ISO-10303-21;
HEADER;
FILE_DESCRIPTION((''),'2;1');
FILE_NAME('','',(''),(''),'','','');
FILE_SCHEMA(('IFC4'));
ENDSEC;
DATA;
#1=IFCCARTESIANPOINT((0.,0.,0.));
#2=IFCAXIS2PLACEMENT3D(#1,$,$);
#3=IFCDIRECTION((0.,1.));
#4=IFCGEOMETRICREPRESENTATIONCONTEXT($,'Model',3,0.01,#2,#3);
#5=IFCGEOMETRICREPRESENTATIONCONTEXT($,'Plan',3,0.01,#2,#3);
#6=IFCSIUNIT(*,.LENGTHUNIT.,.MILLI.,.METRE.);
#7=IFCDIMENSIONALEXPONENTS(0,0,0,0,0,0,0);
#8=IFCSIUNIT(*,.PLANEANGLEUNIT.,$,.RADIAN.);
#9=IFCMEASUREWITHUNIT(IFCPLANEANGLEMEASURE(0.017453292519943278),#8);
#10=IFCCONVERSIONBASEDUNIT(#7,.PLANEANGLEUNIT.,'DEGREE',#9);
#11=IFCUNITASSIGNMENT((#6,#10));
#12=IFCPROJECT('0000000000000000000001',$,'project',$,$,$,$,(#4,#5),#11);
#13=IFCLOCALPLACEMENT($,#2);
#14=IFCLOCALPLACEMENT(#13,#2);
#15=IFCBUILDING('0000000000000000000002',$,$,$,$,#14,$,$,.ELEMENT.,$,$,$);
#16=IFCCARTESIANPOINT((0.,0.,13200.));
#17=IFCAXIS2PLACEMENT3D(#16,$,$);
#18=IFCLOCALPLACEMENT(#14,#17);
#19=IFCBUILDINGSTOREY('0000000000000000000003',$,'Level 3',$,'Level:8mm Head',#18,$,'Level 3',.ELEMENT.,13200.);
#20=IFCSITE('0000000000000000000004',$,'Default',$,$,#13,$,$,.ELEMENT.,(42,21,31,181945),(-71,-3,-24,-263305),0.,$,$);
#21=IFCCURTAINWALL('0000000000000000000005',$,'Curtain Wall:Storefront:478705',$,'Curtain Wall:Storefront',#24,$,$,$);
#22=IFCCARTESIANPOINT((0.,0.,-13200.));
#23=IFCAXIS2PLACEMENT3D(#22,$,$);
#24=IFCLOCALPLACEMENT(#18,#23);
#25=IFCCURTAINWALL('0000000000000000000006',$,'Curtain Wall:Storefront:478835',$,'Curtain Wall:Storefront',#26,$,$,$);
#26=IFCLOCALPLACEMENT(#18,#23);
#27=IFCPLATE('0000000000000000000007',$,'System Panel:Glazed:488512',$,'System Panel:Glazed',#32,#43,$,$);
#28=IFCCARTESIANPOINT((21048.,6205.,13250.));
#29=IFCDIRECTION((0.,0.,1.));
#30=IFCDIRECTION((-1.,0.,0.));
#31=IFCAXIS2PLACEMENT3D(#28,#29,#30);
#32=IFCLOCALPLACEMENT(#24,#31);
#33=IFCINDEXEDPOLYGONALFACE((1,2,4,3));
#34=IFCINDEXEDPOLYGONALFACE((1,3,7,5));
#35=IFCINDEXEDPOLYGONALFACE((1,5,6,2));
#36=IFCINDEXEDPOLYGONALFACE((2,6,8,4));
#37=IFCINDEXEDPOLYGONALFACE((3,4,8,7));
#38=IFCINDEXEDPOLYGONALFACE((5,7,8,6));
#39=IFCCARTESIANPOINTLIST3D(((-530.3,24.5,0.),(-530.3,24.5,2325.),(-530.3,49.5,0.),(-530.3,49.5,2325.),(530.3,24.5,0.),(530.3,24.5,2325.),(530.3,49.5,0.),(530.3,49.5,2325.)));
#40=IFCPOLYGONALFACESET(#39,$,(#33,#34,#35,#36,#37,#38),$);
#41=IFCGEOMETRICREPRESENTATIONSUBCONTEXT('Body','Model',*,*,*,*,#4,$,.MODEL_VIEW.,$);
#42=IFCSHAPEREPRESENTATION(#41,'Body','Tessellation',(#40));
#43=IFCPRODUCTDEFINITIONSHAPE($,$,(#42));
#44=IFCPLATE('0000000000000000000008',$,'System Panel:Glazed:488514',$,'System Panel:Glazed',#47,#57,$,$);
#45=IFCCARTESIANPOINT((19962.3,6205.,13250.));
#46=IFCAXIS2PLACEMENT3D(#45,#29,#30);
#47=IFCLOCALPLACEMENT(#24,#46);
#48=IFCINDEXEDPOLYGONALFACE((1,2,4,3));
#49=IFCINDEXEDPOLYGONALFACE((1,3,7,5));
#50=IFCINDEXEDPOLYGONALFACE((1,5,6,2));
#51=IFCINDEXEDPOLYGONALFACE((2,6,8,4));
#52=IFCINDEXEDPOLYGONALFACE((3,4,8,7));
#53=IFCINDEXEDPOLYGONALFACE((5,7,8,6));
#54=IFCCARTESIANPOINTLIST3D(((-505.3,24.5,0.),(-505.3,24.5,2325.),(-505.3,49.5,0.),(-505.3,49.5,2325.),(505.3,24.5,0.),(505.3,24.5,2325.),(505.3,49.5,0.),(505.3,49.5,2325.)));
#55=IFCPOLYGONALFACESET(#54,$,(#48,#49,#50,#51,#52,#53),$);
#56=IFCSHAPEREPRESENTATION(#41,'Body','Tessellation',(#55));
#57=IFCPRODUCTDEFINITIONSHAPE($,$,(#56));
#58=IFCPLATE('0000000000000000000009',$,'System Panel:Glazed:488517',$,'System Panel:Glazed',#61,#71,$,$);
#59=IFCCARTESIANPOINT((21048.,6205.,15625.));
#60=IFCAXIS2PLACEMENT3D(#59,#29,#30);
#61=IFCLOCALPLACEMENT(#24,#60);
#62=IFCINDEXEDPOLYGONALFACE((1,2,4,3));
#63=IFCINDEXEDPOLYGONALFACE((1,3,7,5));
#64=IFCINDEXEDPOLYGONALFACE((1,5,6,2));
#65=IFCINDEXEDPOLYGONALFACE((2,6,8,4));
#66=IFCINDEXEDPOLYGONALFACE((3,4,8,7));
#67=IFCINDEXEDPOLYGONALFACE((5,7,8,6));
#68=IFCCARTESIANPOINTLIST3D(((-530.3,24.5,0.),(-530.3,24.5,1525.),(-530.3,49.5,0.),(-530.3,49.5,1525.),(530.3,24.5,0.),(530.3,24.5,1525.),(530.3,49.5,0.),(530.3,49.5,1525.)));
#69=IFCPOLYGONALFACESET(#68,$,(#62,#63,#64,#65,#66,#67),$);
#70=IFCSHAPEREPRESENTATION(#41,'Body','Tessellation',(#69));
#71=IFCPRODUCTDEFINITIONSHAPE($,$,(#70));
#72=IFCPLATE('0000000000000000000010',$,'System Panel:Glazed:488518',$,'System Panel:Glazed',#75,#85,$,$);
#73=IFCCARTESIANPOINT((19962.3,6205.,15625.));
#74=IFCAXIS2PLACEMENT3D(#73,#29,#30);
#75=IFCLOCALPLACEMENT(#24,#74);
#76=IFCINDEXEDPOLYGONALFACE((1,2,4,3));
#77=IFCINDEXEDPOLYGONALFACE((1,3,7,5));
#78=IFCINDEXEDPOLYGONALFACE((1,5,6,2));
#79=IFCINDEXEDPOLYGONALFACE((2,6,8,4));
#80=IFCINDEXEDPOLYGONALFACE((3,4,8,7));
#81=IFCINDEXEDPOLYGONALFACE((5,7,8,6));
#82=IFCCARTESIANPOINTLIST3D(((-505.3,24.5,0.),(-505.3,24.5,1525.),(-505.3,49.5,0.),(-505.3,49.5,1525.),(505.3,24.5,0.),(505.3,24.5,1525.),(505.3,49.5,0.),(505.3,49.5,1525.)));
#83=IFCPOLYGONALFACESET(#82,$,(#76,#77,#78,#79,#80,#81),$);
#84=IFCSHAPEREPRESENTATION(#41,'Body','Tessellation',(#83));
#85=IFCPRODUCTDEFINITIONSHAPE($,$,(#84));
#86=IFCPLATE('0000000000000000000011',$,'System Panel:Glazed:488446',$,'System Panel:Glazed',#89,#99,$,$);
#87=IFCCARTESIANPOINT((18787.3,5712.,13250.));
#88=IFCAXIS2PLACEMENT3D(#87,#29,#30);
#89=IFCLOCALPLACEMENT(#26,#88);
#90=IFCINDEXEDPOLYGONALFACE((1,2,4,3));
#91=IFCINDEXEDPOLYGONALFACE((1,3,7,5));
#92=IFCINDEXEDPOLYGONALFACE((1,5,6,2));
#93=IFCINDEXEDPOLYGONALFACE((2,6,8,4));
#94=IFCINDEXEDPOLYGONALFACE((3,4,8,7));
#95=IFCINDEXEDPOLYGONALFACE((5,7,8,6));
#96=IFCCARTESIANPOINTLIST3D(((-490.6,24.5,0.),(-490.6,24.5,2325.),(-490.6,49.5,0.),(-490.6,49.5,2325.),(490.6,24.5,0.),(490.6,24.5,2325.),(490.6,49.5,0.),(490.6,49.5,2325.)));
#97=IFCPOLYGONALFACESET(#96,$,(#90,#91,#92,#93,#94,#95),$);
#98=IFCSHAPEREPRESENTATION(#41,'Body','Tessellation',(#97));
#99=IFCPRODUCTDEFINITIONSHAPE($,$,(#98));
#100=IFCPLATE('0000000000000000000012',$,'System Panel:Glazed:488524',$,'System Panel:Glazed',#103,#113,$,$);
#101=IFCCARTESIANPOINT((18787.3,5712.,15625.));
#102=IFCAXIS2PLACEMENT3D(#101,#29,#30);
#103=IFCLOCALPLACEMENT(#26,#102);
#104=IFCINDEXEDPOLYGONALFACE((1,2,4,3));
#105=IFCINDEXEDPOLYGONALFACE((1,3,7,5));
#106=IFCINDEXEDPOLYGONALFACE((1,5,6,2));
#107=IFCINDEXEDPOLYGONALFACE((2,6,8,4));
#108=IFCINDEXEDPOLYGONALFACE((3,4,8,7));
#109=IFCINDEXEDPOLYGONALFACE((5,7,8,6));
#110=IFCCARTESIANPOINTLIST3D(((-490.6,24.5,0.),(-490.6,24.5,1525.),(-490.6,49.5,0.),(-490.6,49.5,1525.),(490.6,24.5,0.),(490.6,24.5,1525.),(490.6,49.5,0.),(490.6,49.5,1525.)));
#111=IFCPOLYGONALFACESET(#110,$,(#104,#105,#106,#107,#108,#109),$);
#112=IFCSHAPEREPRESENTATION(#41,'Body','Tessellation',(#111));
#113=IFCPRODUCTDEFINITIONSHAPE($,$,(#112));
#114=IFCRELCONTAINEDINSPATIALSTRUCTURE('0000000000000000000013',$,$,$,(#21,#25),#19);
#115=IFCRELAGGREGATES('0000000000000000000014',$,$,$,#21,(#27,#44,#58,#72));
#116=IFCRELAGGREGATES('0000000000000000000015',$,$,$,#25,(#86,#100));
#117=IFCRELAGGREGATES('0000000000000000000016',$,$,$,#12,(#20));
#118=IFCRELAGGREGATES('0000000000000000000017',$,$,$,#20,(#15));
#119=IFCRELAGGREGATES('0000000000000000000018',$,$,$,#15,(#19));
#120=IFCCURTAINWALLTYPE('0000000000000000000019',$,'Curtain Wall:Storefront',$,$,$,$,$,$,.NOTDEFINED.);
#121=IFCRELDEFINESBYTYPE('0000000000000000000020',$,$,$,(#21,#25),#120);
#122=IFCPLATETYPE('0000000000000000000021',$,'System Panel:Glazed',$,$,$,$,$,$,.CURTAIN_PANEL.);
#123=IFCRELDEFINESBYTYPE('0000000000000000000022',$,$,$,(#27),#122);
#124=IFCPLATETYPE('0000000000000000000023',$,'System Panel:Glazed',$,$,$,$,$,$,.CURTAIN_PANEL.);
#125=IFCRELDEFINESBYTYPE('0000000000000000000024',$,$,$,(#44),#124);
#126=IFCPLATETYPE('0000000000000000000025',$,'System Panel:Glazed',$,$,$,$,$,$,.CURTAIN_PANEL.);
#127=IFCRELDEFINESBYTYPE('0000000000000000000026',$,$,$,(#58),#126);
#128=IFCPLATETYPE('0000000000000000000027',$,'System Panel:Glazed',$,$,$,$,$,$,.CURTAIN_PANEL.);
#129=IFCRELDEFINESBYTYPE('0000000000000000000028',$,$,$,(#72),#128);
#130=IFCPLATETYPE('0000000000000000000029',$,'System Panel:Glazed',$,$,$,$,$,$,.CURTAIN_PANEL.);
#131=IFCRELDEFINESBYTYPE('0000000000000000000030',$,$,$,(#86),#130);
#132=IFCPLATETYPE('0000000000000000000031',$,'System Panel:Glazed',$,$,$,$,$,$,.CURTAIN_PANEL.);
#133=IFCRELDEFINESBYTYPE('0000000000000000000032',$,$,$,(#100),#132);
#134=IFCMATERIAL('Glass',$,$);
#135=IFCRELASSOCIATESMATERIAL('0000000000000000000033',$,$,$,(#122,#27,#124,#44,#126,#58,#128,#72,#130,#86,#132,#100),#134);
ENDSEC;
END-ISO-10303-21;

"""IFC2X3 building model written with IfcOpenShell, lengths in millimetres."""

from ifc_helpers import new_model, entity, si_unit, converted_unit, direction, frame, origin, origin_2d_with_axis, place, context, subcontext, project, spatial, rectangle, extrude, source, transform, mapped, material, type_object, type_shapes, element, aggregate, save


model = new_model("IFC2X3")

# Units and contexts
model_context = context("Model", 3, precision=0.01, world=origin(), true_north=direction((0.0, 1.0)))
plan_context = context("Plan", 3, precision=0.01, world=origin(), true_north=direction((0.0, 1.0)))
body_context = subcontext(model_context, "Body", "Model", "MODEL_VIEW")
ifc_project = project(units=[si_unit("LENGTHUNIT", "METRE", prefix="MILLI"), converted_unit("PLANEANGLEUNIT", "DEGREE", entity("IfcPlaneAngleMeasure", 0.017453292519943278), si_unit("PLANEANGLEUNIT", "RADIAN"), dimensions=[0, 0, 0, 0, 0, 0, 0])], contexts=[model_context, plan_context])

# Site, building, storey
site_placement = place(None, origin())
site = spatial("IfcSite", under=ifc_project, at=site_placement, Name="Default", CompositionType="ELEMENT", RefLatitude=(42, 21, 31, 181945), RefLongitude=(-71, -3, -24, -263305), RefElevation=0.0)
building_placement = place(site_placement, origin())
building = spatial("IfcBuilding", under=site, at=building_placement, CompositionType="ELEMENT")
storey_placement = place(building_placement, frame((0.0, 0.0, 13200.0)))
storey = spatial("IfcBuildingStorey", under=building, at=storey_placement, Name="Level 3", ObjectType="Level:8mm Head", LongName="Level 3", CompositionType="ELEMENT", Elevation=13200.0)

# Curtain walls
curtain_wall_type = type_object("IfcCurtainWallType", Name="Curtain Wall:Storefront", PredefinedType="NOTDEFINED")
curtain_wall_1_placement = place(storey_placement, frame((0.0, 0.0, -13200.0)))
curtain_wall_1 = element("IfcCurtainWall", 1, at=curtain_wall_1_placement, inside=storey, type_object=curtain_wall_type, Name="Curtain Wall:Storefront:478705", ObjectType="Curtain Wall:Storefront")
curtain_wall_2_placement = place(storey_placement, frame((0.0, 0.0, -13200.0)))
curtain_wall_2 = element("IfcCurtainWall", 2, at=curtain_wall_2_placement, inside=storey, type_object=curtain_wall_type, Name="Curtain Wall:Storefront:478835", ObjectType="Curtain Wall:Storefront")

# Plates
ifc_material_1 = material(Name="Glass")
plate_type_1 = type_object("IfcPlateType", Name="System Panel:Glazed", PredefinedType="CURTAIN_PANEL", material=ifc_material_1)
shared_shape_1 = source(origin(), body_context, "Body", "SweptSolid", [
    extrude(rectangle(XDim=25.0, YDim=1060.7, at=origin_2d_with_axis()), frame((0.0, 37.0, 0.0), z_axis=(0.0, 0.0, 1.0), x_axis=(0.0, 1.0, 0.0)), (0.0, 0.0, 1.0), 2325.0),
])
type_shapes(plate_type_1, [shared_shape_1])
plate_1_placement = place(curtain_wall_1_placement, frame((21048.0, 6205.0, 13250.0), z_axis=(0.0, 0.0, 1.0), x_axis=(-1.0, 0.0, 0.0)))
plate_1 = element("IfcPlate", 3, at=plate_1_placement, type_object=plate_type_1, material=ifc_material_1, Name="System Panel:Glazed:488512", ObjectType="System Panel:Glazed", context=body_context, shape_type="MappedRepresentation", body=[
    mapped(shared_shape_1, transform((0.0, 0.0, 0.0), scale=1.0)),
])
plate_type_2 = type_object("IfcPlateType", Name="System Panel:Glazed", PredefinedType="CURTAIN_PANEL", material=ifc_material_1)
shared_shape_2 = source(origin(), body_context, "Body", "SweptSolid", [
    extrude(rectangle(XDim=25.0, YDim=1010.7, at=origin_2d_with_axis()), frame((0.0, 37.0, 0.0), z_axis=(0.0, 0.0, 1.0), x_axis=(0.0, 1.0, 0.0)), (0.0, 0.0, 1.0), 2325.0),
])
type_shapes(plate_type_2, [shared_shape_2])
plate_2_placement = place(curtain_wall_1_placement, frame((19962.3, 6205.0, 13250.0), z_axis=(0.0, 0.0, 1.0), x_axis=(-1.0, 0.0, 0.0)))
plate_2 = element("IfcPlate", 4, at=plate_2_placement, type_object=plate_type_2, material=ifc_material_1, Name="System Panel:Glazed:488514", ObjectType="System Panel:Glazed", context=body_context, shape_type="MappedRepresentation", body=[
    mapped(shared_shape_2, transform((0.0, 0.0, 0.0), scale=1.0)),
])
plate_type_3 = type_object("IfcPlateType", Name="System Panel:Glazed", PredefinedType="CURTAIN_PANEL", material=ifc_material_1)
shared_shape_3 = source(origin(), body_context, "Body", "SweptSolid", [
    extrude(rectangle(XDim=25.0, YDim=1060.7, at=origin_2d_with_axis()), frame((0.0, 37.0, 0.0), z_axis=(0.0, 0.0, 1.0), x_axis=(0.0, 1.0, 0.0)), (0.0, 0.0, 1.0), 1525.0),
])
type_shapes(plate_type_3, [shared_shape_3])
plate_3_placement = place(curtain_wall_1_placement, frame((21048.0, 6205.0, 15625.0), z_axis=(0.0, 0.0, 1.0), x_axis=(-1.0, 0.0, 0.0)))
plate_3 = element("IfcPlate", 5, at=plate_3_placement, type_object=plate_type_3, material=ifc_material_1, Name="System Panel:Glazed:488517", ObjectType="System Panel:Glazed", context=body_context, shape_type="MappedRepresentation", body=[
    mapped(shared_shape_3, transform((0.0, 0.0, 0.0), scale=1.0)),
])
plate_type_4 = type_object("IfcPlateType", Name="System Panel:Glazed", PredefinedType="CURTAIN_PANEL", material=ifc_material_1)
shared_shape_4 = source(origin(), body_context, "Body", "SweptSolid", [
    extrude(rectangle(XDim=25.0, YDim=1010.7, at=origin_2d_with_axis()), frame((0.0, 37.0, 0.0), z_axis=(0.0, 0.0, 1.0), x_axis=(0.0, 1.0, 0.0)), (0.0, 0.0, 1.0), 1525.0),
])
type_shapes(plate_type_4, [shared_shape_4])
plate_4_placement = place(curtain_wall_1_placement, frame((19962.3, 6205.0, 15625.0), z_axis=(0.0, 0.0, 1.0), x_axis=(-1.0, 0.0, 0.0)))
plate_4 = element("IfcPlate", 6, at=plate_4_placement, type_object=plate_type_4, material=ifc_material_1, Name="System Panel:Glazed:488518", ObjectType="System Panel:Glazed", context=body_context, shape_type="MappedRepresentation", body=[
    mapped(shared_shape_4, transform((0.0, 0.0, 0.0), scale=1.0)),
])
aggregate(curtain_wall_1, [plate_1, plate_2, plate_3, plate_4])
plate_type_5 = type_object("IfcPlateType", Name="System Panel:Glazed", PredefinedType="CURTAIN_PANEL", material=ifc_material_1)
shared_shape_5 = source(origin(), body_context, "Body", "SweptSolid", [
    extrude(rectangle(XDim=25.0, YDim=981.3, at=origin_2d_with_axis()), frame((0.0, 37.0, 0.0), z_axis=(0.0, 0.0, 1.0), x_axis=(0.0, 1.0, 0.0)), (0.0, 0.0, 1.0), 2325.0),
])
type_shapes(plate_type_5, [shared_shape_5])
plate_5_placement = place(curtain_wall_2_placement, frame((18787.3, 5712.0, 13250.0), z_axis=(0.0, 0.0, 1.0), x_axis=(-1.0, 0.0, 0.0)))
plate_5 = element("IfcPlate", 7, at=plate_5_placement, type_object=plate_type_5, material=ifc_material_1, Name="System Panel:Glazed:488446", ObjectType="System Panel:Glazed", context=body_context, shape_type="MappedRepresentation", body=[
    mapped(shared_shape_5, transform((0.0, 0.0, 0.0), scale=1.0)),
])
plate_type_6 = type_object("IfcPlateType", Name="System Panel:Glazed", PredefinedType="CURTAIN_PANEL", material=ifc_material_1)
shared_shape_6 = source(origin(), body_context, "Body", "SweptSolid", [
    extrude(rectangle(XDim=25.0, YDim=981.3, at=origin_2d_with_axis()), frame((0.0, 37.0, 0.0), z_axis=(0.0, 0.0, 1.0), x_axis=(0.0, 1.0, 0.0)), (0.0, 0.0, 1.0), 1525.0),
])
type_shapes(plate_type_6, [shared_shape_6])
plate_6_placement = place(curtain_wall_2_placement, frame((18787.3, 5712.0, 15625.0), z_axis=(0.0, 0.0, 1.0), x_axis=(-1.0, 0.0, 0.0)))
plate_6 = element("IfcPlate", 8, at=plate_6_placement, type_object=plate_type_6, material=ifc_material_1, Name="System Panel:Glazed:488524", ObjectType="System Panel:Glazed", context=body_context, shape_type="MappedRepresentation", body=[
    mapped(shared_shape_6, transform((0.0, 0.0, 0.0), scale=1.0)),
])
aggregate(curtain_wall_2, [plate_5, plate_6])

save(model, "model.ifc")
